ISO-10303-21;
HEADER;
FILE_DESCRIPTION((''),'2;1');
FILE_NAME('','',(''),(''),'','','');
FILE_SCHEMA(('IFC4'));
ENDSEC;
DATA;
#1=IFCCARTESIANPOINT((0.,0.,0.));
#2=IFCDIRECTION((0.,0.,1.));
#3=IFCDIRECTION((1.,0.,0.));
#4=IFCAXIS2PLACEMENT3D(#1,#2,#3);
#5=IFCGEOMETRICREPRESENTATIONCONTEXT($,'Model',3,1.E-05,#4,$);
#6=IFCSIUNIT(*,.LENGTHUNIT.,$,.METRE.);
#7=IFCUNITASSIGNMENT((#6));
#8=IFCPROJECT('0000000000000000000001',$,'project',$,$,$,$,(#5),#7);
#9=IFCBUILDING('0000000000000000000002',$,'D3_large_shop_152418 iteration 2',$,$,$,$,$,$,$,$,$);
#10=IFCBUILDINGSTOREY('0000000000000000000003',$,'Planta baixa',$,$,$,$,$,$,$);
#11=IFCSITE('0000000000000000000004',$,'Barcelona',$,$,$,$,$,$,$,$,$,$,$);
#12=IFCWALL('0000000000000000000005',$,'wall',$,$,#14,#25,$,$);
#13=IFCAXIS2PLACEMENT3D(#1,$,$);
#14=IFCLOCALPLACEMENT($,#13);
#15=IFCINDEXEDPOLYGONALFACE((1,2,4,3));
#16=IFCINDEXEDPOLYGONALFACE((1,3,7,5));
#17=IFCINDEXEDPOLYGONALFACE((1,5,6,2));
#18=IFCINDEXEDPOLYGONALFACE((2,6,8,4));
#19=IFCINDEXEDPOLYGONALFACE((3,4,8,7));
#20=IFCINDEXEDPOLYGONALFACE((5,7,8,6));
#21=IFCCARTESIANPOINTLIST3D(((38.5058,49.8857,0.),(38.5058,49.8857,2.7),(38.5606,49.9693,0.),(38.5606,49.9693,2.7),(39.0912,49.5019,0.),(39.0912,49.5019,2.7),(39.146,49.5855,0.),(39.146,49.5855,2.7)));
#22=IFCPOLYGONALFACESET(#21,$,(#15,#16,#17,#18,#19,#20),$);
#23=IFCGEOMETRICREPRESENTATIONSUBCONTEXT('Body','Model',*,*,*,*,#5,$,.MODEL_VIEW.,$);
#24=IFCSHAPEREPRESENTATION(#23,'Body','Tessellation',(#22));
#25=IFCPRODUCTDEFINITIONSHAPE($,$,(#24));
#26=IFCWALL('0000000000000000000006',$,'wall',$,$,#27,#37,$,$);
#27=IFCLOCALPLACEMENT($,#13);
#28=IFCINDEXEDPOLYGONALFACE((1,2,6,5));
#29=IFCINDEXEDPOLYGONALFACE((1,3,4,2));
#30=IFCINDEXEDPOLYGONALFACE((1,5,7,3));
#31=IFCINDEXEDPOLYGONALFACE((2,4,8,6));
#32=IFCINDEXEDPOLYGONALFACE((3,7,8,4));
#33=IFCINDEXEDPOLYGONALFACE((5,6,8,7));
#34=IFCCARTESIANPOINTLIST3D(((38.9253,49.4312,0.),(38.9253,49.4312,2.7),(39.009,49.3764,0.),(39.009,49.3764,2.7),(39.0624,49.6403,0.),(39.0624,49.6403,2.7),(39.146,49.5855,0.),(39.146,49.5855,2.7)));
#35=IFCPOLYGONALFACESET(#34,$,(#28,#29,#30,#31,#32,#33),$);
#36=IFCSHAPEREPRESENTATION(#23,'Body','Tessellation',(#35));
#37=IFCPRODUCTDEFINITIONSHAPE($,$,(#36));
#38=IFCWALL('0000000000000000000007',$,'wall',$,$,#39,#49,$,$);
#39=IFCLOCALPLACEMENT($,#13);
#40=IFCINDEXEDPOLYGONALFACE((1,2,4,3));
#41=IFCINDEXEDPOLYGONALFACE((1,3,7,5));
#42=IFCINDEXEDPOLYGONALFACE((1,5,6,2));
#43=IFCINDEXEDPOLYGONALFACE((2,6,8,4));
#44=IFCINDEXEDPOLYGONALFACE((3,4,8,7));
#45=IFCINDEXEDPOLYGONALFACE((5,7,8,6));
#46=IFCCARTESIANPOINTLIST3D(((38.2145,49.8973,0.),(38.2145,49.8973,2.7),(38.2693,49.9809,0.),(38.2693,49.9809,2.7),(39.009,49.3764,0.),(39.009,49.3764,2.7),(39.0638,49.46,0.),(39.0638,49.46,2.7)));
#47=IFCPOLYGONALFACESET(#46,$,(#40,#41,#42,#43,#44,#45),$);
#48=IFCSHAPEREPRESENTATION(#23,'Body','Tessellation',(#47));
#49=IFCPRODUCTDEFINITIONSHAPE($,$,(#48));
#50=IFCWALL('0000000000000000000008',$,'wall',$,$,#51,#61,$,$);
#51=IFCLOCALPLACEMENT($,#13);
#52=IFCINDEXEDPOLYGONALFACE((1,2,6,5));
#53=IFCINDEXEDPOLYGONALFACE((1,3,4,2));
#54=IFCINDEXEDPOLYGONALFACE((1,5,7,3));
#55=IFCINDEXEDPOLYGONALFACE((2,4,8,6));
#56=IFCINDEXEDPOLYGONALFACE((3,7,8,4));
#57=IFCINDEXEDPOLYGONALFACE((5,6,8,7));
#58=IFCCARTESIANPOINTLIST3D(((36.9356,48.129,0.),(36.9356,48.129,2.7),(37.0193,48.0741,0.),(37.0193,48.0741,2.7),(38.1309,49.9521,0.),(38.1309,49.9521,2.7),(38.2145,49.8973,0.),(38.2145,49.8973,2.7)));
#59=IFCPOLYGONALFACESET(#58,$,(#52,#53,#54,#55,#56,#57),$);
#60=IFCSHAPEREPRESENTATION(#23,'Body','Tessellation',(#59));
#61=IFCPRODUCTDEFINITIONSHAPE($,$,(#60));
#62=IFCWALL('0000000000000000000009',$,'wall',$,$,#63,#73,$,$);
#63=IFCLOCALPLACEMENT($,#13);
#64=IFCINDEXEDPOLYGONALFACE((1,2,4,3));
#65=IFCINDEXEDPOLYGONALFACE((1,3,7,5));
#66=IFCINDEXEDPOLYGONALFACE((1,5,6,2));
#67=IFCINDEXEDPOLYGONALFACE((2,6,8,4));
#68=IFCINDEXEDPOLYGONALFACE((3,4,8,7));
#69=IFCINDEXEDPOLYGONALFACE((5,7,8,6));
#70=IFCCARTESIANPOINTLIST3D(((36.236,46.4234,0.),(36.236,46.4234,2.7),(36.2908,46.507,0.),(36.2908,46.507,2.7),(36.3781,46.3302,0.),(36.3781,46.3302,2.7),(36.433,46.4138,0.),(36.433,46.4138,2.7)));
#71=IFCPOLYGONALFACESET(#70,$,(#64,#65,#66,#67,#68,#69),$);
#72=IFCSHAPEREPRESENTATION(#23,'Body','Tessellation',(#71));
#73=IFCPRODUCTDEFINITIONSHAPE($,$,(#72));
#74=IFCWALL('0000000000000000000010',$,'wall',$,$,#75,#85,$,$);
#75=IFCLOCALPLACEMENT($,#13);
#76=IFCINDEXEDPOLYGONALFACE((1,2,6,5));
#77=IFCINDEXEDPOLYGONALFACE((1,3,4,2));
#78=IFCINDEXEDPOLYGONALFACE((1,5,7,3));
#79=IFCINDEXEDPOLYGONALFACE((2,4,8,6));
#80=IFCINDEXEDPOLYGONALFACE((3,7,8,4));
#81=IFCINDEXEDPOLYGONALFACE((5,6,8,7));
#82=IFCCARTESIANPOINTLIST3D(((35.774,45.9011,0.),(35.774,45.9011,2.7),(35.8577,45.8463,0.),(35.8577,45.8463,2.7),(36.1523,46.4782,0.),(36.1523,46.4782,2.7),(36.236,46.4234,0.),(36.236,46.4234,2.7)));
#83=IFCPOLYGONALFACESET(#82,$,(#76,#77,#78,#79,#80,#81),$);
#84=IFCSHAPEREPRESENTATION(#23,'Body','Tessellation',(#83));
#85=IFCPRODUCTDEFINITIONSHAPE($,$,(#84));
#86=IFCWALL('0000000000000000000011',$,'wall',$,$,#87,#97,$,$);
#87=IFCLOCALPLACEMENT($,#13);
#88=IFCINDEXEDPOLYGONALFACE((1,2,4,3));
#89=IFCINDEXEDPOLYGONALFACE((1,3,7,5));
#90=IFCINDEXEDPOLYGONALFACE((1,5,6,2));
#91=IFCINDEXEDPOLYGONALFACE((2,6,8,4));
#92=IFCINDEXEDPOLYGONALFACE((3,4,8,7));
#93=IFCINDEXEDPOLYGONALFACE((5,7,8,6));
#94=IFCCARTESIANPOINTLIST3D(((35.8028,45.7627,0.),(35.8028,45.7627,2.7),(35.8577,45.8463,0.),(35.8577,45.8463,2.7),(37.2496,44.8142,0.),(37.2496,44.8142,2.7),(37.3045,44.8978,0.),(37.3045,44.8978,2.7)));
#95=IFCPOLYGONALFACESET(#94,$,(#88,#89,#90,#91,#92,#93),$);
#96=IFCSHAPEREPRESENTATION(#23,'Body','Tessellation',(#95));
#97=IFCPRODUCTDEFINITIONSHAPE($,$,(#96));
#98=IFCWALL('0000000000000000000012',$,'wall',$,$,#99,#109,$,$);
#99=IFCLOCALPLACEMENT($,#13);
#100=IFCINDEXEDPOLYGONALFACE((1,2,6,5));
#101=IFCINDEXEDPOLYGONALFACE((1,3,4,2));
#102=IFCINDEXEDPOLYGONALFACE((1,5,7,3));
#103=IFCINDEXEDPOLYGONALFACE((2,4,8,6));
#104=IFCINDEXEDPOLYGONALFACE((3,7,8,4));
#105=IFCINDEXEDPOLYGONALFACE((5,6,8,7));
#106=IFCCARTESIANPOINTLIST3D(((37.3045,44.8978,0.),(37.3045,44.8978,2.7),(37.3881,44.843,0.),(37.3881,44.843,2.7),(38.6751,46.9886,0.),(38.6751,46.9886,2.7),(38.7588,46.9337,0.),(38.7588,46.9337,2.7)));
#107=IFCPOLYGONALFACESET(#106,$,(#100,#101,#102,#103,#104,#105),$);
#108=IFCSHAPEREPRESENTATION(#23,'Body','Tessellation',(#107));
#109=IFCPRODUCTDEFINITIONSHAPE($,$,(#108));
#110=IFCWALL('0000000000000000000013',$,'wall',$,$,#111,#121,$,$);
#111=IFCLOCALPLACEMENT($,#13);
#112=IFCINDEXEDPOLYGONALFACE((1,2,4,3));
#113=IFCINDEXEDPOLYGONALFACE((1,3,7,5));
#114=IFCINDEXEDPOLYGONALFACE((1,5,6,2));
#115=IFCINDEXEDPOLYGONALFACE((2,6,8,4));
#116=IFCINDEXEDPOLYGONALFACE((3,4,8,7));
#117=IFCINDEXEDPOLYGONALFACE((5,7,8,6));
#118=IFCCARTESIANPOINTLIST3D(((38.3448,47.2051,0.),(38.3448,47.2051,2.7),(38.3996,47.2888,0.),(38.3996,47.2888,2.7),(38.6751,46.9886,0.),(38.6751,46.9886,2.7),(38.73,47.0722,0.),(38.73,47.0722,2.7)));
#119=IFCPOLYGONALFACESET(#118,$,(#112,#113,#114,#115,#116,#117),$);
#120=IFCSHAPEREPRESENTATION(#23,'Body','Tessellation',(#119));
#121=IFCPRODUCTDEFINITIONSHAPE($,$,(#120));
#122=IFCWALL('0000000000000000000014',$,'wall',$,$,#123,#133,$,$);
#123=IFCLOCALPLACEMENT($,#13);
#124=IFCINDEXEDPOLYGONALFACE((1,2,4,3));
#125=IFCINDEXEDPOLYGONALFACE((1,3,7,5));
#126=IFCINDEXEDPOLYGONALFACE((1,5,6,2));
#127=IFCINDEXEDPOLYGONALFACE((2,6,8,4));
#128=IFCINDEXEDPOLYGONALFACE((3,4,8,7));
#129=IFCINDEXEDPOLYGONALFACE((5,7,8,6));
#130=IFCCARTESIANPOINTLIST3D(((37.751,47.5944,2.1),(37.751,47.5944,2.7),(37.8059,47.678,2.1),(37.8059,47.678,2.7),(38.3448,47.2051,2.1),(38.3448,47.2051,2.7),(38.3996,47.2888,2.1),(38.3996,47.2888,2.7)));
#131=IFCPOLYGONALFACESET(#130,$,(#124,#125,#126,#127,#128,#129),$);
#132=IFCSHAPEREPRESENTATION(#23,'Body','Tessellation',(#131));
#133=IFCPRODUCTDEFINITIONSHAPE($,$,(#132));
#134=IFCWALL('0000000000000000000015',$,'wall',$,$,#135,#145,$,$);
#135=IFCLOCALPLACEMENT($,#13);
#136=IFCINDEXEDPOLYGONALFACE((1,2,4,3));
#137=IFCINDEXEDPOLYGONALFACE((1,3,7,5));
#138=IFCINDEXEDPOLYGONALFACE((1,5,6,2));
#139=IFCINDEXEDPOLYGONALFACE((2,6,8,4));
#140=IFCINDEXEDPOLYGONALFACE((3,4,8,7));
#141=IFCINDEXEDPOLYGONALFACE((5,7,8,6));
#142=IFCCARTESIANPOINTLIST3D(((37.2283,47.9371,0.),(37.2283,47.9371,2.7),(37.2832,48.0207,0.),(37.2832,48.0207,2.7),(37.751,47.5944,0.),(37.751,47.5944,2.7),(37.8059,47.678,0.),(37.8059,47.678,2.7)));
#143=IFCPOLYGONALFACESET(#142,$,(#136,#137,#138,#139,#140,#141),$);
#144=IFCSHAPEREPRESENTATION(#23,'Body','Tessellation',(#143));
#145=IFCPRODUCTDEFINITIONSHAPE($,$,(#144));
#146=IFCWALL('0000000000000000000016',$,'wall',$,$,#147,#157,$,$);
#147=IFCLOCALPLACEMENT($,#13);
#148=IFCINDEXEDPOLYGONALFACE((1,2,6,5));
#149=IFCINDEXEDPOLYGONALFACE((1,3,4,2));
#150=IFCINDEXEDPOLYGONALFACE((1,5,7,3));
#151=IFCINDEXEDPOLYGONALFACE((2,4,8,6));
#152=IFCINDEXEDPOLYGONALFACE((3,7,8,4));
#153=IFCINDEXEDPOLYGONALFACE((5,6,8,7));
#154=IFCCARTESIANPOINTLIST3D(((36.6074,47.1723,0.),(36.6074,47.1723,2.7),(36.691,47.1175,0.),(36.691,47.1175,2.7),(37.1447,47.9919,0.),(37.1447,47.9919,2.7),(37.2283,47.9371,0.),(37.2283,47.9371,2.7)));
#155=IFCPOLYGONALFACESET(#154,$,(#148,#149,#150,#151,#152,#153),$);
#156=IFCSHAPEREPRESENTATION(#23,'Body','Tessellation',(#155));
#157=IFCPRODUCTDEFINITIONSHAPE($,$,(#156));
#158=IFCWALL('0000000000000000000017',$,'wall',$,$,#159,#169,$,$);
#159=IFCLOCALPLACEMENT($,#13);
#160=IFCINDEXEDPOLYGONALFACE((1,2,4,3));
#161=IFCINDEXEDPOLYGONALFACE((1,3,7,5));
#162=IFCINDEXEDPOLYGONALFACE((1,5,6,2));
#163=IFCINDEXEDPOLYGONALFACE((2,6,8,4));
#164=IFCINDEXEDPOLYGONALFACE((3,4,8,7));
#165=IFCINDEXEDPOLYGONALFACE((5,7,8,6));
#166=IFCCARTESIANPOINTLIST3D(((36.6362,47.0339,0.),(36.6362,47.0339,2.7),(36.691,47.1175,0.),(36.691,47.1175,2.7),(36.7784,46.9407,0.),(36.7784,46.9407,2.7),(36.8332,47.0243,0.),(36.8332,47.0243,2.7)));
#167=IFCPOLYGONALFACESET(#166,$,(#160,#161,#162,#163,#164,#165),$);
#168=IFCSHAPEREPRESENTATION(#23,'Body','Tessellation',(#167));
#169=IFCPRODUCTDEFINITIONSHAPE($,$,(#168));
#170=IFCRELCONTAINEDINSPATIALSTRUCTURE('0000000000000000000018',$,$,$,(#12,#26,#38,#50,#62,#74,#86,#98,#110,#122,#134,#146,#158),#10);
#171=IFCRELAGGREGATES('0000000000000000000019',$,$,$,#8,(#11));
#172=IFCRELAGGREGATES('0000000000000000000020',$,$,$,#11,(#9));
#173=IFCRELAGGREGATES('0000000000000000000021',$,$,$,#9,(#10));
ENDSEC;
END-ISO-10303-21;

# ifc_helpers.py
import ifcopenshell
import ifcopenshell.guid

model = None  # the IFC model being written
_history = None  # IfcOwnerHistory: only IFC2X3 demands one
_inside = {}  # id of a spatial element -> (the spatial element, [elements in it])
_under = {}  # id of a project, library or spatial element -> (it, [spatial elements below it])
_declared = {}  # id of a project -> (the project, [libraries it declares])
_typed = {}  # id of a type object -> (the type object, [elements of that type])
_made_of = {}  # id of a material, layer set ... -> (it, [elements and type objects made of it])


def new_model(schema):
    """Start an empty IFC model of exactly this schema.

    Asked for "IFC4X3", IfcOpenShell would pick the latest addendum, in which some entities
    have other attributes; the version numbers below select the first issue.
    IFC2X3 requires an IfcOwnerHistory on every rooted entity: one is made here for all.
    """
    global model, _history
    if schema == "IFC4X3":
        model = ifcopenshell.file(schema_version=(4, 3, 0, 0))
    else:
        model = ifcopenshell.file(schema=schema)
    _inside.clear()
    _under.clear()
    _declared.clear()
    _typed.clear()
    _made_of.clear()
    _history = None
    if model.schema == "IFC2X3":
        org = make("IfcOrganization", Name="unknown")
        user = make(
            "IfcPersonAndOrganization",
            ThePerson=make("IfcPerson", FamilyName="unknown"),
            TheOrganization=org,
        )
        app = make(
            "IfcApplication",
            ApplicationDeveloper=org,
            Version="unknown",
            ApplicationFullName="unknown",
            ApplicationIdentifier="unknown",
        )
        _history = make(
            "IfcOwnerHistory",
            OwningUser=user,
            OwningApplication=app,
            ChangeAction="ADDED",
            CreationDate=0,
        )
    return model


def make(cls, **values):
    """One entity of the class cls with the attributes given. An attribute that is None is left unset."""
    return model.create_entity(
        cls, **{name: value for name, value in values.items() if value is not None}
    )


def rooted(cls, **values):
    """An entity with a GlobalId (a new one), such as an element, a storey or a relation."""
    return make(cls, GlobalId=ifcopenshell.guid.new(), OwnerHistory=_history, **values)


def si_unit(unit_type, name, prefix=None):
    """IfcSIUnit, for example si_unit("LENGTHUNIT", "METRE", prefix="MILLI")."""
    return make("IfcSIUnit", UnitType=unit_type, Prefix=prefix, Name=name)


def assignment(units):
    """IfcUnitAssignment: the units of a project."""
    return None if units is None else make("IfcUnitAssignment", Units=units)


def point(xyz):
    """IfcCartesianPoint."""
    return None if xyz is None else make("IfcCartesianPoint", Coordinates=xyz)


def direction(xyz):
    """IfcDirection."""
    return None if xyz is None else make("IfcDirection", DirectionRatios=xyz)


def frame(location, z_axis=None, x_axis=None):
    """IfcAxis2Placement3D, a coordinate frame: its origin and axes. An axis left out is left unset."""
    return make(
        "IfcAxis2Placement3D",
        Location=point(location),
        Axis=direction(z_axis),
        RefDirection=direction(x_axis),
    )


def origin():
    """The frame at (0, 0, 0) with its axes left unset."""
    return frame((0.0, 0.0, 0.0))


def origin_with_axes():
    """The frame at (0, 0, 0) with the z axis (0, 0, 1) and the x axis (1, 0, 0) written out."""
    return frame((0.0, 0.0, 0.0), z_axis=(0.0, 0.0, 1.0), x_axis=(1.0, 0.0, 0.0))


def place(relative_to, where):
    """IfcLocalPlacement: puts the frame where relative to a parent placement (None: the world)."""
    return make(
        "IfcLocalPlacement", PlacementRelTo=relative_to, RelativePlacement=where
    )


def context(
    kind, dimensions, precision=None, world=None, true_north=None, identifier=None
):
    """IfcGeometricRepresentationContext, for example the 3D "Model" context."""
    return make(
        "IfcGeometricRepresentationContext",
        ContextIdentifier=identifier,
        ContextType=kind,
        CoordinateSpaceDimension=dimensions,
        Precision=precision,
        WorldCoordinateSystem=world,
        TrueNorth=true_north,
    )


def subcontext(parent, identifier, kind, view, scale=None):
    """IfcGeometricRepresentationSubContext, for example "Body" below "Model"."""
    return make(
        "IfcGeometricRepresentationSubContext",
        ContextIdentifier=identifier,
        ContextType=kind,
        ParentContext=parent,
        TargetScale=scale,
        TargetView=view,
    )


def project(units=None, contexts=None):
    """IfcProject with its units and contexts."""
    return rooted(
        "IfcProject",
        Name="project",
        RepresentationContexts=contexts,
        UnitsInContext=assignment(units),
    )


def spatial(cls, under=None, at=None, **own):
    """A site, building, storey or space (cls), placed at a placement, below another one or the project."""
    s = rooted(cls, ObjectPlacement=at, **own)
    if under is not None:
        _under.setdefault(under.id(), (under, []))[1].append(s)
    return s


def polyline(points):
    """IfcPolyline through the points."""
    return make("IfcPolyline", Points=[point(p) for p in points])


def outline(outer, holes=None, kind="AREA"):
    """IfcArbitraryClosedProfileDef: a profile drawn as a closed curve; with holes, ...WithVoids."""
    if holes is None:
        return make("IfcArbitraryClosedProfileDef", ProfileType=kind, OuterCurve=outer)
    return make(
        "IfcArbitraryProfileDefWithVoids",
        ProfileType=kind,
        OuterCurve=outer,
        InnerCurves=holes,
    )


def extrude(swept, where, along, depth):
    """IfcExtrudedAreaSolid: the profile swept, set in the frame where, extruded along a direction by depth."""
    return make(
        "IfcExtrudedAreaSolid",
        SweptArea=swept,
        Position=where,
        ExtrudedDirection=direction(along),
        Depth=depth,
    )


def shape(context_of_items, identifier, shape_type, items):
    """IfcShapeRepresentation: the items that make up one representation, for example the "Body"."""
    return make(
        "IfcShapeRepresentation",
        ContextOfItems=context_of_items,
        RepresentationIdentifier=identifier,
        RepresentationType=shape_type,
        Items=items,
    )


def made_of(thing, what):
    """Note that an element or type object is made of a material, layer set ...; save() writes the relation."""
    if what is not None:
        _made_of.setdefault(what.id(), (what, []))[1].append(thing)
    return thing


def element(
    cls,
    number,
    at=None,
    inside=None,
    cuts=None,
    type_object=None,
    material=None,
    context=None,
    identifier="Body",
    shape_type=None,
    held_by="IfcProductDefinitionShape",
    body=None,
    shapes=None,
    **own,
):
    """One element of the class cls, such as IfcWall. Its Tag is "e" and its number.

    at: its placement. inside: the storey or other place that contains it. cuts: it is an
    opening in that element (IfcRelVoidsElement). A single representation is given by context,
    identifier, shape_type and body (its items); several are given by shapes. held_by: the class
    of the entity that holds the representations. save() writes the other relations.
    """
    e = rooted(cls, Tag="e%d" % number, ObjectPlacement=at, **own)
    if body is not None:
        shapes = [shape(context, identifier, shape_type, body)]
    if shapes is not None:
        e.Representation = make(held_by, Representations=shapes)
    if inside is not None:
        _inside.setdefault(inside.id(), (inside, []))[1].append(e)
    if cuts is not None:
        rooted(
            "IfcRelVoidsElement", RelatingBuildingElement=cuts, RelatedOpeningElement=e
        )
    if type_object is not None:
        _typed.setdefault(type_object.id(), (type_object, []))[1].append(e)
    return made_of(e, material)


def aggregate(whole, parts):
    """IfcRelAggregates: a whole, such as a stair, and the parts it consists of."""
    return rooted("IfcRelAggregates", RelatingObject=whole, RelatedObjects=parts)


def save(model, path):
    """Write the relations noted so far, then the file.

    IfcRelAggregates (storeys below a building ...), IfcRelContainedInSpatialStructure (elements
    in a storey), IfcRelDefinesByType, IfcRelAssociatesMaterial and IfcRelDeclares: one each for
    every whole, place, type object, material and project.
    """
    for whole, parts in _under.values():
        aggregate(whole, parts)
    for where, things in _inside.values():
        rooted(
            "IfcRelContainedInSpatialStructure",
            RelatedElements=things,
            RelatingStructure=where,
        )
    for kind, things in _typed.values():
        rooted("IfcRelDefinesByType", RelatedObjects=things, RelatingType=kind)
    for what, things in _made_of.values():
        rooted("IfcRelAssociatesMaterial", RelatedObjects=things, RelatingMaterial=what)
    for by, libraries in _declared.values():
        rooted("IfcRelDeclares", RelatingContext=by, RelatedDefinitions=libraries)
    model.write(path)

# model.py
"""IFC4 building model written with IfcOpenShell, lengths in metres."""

from ifc_helpers import new_model, si_unit, frame, origin, origin_with_axes, place, context, subcontext, project, spatial, polyline, outline, extrude, element, save


model = new_model("IFC4")

# Units and contexts
model_context = context("Model", 3, precision=1e-05, world=origin_with_axes())
body_context = subcontext(model_context, "Body", "Model", "MODEL_VIEW")
ifc_project = project(units=[si_unit("LENGTHUNIT", "METRE")], contexts=[model_context])

# Site, building, storey
site = spatial("IfcSite", under=ifc_project, Name="Barcelona")
building = spatial("IfcBuilding", under=site, Name="D3_large_shop_152418 iteration 2")
storey = spatial("IfcBuildingStorey", under=building, Name="Planta baixa")

# Walls
wall_1_placement = place(None, origin_with_axes())
element("IfcWall", 1, at=wall_1_placement, inside=storey, Name="wall", context=body_context, shape_type="SweptSolid", body=[
    extrude(outline(polyline([(38.5606, 49.9693), (39.146, 49.5855), (39.0912, 49.5019), (38.5058, 49.8857), (38.5606, 49.9693)])), origin(), (0.0, 0.0, 1.0), 2.7),
])
wall_2_placement = place(None, origin_with_axes())
element("IfcWall", 2, at=wall_2_placement, inside=storey, Name="wall", context=body_context, shape_type="SweptSolid", body=[
    extrude(outline(polyline([(39.146, 49.5855), (39.009, 49.3764), (38.9253, 49.4312), (39.0624, 49.6403), (39.146, 49.5855)])), origin(), (0.0, 0.0, 1.0), 2.7),
])
wall_3_placement = place(None, origin_with_axes())
element("IfcWall", 3, at=wall_3_placement, inside=storey, Name="wall", context=body_context, shape_type="SweptSolid", body=[
    extrude(outline(polyline([(39.009, 49.3764), (38.2145, 49.8973), (38.2693, 49.9809), (39.0638, 49.46), (39.009, 49.3764)])), origin(), (0.0, 0.0, 1.0), 2.7),
])
wall_4_placement = place(None, origin_with_axes())
element("IfcWall", 4, at=wall_4_placement, inside=storey, Name="wall", context=body_context, shape_type="SweptSolid", body=[
    extrude(outline(polyline([(38.2145, 49.8973), (37.0193, 48.0741), (36.9356, 48.129), (38.1309, 49.9521), (38.2145, 49.8973)])), origin(), (0.0, 0.0, 1.0), 2.7),
])
wall_5_placement = place(None, origin_with_axes())
element("IfcWall", 5, at=wall_5_placement, inside=storey, Name="wall", context=body_context, shape_type="SweptSolid", body=[
    extrude(outline(polyline([(36.3781, 46.3302), (36.236, 46.4234), (36.2908, 46.507), (36.433, 46.4138), (36.3781, 46.3302)])), origin(), (0.0, 0.0, 1.0), 2.7),
])
wall_6_placement = place(None, origin_with_axes())
element("IfcWall", 6, at=wall_6_placement, inside=storey, Name="wall", context=body_context, shape_type="SweptSolid", body=[
    extrude(outline(polyline([(36.236, 46.4234), (35.8577, 45.8463), (35.774, 45.9011), (36.1523, 46.4782), (36.236, 46.4234)])), origin(), (0.0, 0.0, 1.0), 2.7),
])
wall_7_placement = place(None, origin_with_axes())
element("IfcWall", 7, at=wall_7_placement, inside=storey, Name="wall", context=body_context, shape_type="SweptSolid", body=[
    extrude(outline(polyline([(35.8577, 45.8463), (37.3045, 44.8978), (37.2496, 44.8142), (35.8028, 45.7627), (35.8577, 45.8463)])), origin(), (0.0, 0.0, 1.0), 2.7),
])
wall_8_placement = place(None, origin_with_axes())
element("IfcWall", 8, at=wall_8_placement, inside=storey, Name="wall", context=body_context, shape_type="SweptSolid", body=[
    extrude(outline(polyline([(37.3045, 44.8978), (38.6751, 46.9886), (38.7588, 46.9337), (37.3881, 44.843), (37.3045, 44.8978)])), origin(), (0.0, 0.0, 1.0), 2.7),
])
wall_9_placement = place(None, origin_with_axes())
element("IfcWall", 9, at=wall_9_placement, inside=storey, Name="wall", context=body_context, shape_type="SweptSolid", body=[
    extrude(outline(polyline([(38.6751, 46.9886), (38.3448, 47.2051), (38.3996, 47.2888), (38.73, 47.0722), (38.6751, 46.9886)])), origin(), (0.0, 0.0, 1.0), 2.7),
])
wall_10_placement = place(None, origin_with_axes())
element("IfcWall", 10, at=wall_10_placement, inside=storey, Name="wall", context=body_context, shape_type="SweptSolid", body=[
    extrude(outline(polyline([(38.3448, 47.2051), (37.751, 47.5944), (37.8059, 47.678), (38.3996, 47.2888), (38.3448, 47.2051)])), frame((0.0, 0.0, 2.1)), (0.0, 0.0, 1.0), 0.6),
])
wall_11_placement = place(None, origin_with_axes())
element("IfcWall", 11, at=wall_11_placement, inside=storey, Name="wall", context=body_context, shape_type="SweptSolid", body=[
    extrude(outline(polyline([(37.751, 47.5944), (37.2283, 47.9371), (37.2832, 48.0207), (37.8059, 47.678), (37.751, 47.5944)])), origin(), (0.0, 0.0, 1.0), 2.7),
])
wall_12_placement = place(None, origin_with_axes())
element("IfcWall", 12, at=wall_12_placement, inside=storey, Name="wall", context=body_context, shape_type="SweptSolid", body=[
    extrude(outline(polyline([(37.2283, 47.9371), (36.691, 47.1175), (36.6074, 47.1723), (37.1447, 47.9919), (37.2283, 47.9371)])), origin(), (0.0, 0.0, 1.0), 2.7),
])
wall_13_placement = place(None, origin_with_axes())
element("IfcWall", 13, at=wall_13_placement, inside=storey, Name="wall", context=body_context, shape_type="SweptSolid", body=[
    extrude(outline(polyline([(36.691, 47.1175), (36.8332, 47.0243), (36.7784, 46.9407), (36.6362, 47.0339), (36.691, 47.1175)])), origin(), (0.0, 0.0, 1.0), 2.7),
])

save(model, "model.ifc")
